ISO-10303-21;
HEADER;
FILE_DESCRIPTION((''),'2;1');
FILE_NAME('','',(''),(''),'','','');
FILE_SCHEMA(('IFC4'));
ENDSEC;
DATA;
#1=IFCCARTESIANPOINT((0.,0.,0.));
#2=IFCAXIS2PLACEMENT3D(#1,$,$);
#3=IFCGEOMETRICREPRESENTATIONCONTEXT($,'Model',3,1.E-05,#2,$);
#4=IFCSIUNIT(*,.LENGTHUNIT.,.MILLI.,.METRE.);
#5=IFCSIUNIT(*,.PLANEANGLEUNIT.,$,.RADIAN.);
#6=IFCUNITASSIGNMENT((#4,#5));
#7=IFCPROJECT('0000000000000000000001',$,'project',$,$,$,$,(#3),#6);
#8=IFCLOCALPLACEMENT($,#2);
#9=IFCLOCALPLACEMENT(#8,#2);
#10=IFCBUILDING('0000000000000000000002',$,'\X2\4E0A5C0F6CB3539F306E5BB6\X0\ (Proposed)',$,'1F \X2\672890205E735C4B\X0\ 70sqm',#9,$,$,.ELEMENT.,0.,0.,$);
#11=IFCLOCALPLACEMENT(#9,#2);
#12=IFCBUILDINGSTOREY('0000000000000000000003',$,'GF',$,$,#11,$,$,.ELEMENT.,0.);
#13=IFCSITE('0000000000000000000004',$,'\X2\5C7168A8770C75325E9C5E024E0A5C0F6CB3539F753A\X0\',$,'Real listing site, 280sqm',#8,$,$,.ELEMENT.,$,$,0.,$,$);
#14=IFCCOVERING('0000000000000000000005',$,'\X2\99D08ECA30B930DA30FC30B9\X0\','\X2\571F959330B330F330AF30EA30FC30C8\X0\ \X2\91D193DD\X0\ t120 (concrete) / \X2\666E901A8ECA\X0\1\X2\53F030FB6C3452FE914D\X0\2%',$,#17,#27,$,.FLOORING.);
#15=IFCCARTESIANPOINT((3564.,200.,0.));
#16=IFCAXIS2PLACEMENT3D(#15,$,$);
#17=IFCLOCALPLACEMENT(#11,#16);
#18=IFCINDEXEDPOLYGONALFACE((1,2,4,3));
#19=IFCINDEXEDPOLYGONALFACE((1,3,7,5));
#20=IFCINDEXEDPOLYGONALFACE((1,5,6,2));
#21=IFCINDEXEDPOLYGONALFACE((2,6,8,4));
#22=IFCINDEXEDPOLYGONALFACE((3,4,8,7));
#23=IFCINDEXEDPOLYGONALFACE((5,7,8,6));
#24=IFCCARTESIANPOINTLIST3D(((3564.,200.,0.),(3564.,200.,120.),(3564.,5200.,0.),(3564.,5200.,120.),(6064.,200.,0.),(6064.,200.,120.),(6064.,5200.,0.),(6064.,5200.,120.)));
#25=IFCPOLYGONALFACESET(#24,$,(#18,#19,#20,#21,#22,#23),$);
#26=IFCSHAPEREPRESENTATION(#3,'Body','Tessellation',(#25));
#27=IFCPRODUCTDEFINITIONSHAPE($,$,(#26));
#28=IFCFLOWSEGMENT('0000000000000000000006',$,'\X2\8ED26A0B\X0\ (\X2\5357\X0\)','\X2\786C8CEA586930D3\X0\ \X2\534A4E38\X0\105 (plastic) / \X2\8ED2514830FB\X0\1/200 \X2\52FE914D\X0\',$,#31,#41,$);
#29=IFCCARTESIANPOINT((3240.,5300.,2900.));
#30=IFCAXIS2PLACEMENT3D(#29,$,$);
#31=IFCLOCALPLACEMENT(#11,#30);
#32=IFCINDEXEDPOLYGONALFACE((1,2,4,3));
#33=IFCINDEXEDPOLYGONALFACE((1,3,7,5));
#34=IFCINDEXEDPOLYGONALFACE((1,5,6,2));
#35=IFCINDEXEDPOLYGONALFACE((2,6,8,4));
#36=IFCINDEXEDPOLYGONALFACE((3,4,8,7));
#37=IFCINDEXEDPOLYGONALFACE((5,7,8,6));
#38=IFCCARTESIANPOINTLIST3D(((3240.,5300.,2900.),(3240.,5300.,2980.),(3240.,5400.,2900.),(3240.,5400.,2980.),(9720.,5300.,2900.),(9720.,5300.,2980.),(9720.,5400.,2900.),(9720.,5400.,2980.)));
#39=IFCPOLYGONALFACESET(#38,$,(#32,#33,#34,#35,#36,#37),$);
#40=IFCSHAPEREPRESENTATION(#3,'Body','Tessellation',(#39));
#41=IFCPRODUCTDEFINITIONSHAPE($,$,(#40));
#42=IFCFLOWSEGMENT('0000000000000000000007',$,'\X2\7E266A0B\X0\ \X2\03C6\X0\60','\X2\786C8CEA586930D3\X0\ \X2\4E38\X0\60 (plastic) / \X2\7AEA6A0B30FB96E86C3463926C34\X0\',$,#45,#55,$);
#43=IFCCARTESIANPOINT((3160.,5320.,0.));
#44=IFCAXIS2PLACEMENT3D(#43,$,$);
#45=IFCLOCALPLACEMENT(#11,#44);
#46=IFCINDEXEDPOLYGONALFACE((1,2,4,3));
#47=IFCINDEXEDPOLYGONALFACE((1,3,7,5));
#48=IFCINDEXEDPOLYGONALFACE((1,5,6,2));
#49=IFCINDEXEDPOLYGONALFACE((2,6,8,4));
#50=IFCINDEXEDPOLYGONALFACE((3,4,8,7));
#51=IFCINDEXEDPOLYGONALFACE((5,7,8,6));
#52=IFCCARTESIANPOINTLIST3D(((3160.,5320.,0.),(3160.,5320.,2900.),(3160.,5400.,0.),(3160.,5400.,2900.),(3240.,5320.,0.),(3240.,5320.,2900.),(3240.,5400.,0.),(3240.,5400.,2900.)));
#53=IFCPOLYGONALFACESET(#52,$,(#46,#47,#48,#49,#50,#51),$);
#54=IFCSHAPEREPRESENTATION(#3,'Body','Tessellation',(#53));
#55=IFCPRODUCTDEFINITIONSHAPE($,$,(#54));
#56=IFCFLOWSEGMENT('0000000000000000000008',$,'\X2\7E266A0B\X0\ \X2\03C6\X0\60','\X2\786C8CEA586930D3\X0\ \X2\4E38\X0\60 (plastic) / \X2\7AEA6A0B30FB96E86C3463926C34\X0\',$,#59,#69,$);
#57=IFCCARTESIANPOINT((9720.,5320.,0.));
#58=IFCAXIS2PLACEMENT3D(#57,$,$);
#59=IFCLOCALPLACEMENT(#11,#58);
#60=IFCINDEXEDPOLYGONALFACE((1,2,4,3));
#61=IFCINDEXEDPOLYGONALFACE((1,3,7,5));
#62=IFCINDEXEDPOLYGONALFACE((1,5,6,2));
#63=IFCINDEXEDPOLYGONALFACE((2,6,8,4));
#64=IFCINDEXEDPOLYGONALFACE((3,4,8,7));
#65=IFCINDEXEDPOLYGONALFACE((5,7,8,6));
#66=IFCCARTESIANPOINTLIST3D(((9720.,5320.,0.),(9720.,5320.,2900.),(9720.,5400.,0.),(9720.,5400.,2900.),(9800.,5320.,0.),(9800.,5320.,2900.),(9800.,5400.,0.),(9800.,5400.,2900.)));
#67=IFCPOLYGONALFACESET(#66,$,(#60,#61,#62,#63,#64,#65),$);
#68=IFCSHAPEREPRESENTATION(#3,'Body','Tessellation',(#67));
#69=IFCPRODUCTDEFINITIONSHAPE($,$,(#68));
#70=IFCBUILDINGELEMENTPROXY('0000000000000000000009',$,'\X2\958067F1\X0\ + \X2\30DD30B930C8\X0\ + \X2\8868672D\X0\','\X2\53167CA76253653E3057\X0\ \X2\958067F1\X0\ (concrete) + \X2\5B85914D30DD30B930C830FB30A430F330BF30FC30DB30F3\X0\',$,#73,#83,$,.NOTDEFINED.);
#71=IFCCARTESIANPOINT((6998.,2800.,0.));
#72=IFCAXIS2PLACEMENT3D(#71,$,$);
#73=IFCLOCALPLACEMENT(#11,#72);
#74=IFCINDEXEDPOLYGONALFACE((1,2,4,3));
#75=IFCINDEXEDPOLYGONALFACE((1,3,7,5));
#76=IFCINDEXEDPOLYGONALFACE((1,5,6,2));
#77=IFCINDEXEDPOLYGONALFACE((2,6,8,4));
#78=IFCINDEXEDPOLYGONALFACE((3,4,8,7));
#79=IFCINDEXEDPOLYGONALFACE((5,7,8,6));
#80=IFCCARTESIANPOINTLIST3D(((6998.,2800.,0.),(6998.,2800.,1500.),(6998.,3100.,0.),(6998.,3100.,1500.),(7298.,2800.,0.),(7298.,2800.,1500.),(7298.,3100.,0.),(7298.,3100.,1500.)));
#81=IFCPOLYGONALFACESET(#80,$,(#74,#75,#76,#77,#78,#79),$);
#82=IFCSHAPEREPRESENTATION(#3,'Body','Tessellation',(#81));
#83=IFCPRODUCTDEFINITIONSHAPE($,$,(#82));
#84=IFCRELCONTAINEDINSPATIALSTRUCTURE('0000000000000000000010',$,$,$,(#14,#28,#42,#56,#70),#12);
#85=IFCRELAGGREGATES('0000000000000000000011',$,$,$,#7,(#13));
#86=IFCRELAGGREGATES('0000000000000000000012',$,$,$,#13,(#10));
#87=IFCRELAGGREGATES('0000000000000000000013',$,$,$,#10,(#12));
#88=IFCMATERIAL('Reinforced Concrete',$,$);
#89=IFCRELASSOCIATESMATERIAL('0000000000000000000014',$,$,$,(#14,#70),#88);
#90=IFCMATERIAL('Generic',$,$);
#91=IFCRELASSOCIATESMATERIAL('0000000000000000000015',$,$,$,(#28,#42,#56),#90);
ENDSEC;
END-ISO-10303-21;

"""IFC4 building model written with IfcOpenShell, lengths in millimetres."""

from ifc_helpers import new_model, si_unit, frame, frame_2d, origin, place, context, project, spatial, rectangle, extrude, material, element, save


model = new_model("IFC4")

# Units and contexts
model_context = context("Model", 3, precision=1e-05, world=origin())
ifc_project = project(units=[si_unit("LENGTHUNIT", "METRE", prefix="MILLI"), si_unit("PLANEANGLEUNIT", "RADIAN")], contexts=[model_context])

# Site, building, storey
site_placement = place(None, origin())
site = spatial("IfcSite", under=ifc_project, at=site_placement, Name="山梨県甲府市上小河原町", ObjectType="Real listing site, 280sqm", CompositionType="ELEMENT", RefElevation=0.0)
building_placement = place(site_placement, origin())
building = spatial("IfcBuilding", under=site, at=building_placement, Name="上小河原の家 (Proposed)", ObjectType="1F 木造平屋 70sqm", CompositionType="ELEMENT", ElevationOfRefHeight=0.0, ElevationOfTerrain=0.0)
storey_placement = place(building_placement, origin())
storey = spatial("IfcBuildingStorey", under=building, at=storey_placement, Name="GF", CompositionType="ELEMENT", Elevation=0.0)

# Shared definitions
ifc_material_1 = material(Name="Reinforced Concrete")

# Covering
covering_1_placement = place(storey_placement, frame((3564.0, 200.0, 0.0)))
element("IfcCovering", 1, at=covering_1_placement, inside=storey, material=ifc_material_1, Name="駐車スペース", Description="土間コンクリート 金鏝 t120 (concrete) / 普通車1台・水勾配2%", PredefinedType="FLOORING", context=model_context, shape_type="SweptSolid", body=[
    extrude(rectangle(XDim=2500.0, YDim=5000.0, at=frame_2d((1250.0, 2500.0))), frame((3564.0, 200.0, 0.0)), (0.0, 0.0, 1.0), 120.0),
])

# Flow segments
ifc_material_2 = material(Name="Generic")
flow_segment_1_placement = place(storey_placement, frame((3240.0, 5300.0, 2900.0)))
element("IfcFlowSegment", 2, at=flow_segment_1_placement, inside=storey, material=ifc_material_2, Name="軒樋 (南)", Description="硬質塩ビ 半丸105 (plastic) / 軒先・1/200 勾配", context=model_context, shape_type="SweptSolid", body=[
    extrude(rectangle(XDim=6480.0, YDim=100.0, at=frame_2d((3240.0, 50.0))), frame((3240.0, 5300.0, 2900.0)), (0.0, 0.0, 1.0), 80.0),
])
flow_segment_2_placement = place(storey_placement, frame((3160.0, 5320.0, 0.0)))
element("IfcFlowSegment", 3, at=flow_segment_2_placement, inside=storey, material=ifc_material_2, Name="縦樋 φ60", Description="硬質塩ビ 丸60 (plastic) / 竪樋・雨水排水", context=model_context, shape_type="SweptSolid", body=[
    extrude(rectangle(XDim=80.0, YDim=80.0, at=frame_2d((40.0, 40.0))), frame((3160.0, 5320.0, 0.0)), (0.0, 0.0, 1.0), 2900.0),
])
flow_segment_3_placement = place(storey_placement, frame((9720.0, 5320.0, 0.0)))
element("IfcFlowSegment", 4, at=flow_segment_3_placement, inside=storey, material=ifc_material_2, Name="縦樋 φ60", Description="硬質塩ビ 丸60 (plastic) / 竪樋・雨水排水", context=model_context, shape_type="SweptSolid", body=[
    extrude(rectangle(XDim=80.0, YDim=80.0, at=frame_2d((40.0, 40.0))), frame((9720.0, 5320.0, 0.0)), (0.0, 0.0, 1.0), 2900.0),
])

# Building element proxy
proxy_placement = place(storey_placement, frame((6998.0, 2800.0, 0.0)))
element("IfcBuildingElementProxy", 5, at=proxy_placement, inside=storey, material=ifc_material_1, Name="門柱 + ポスト + 表札", Description="化粧打放し 門柱 (concrete) + 宅配ポスト・インターホン", PredefinedType="NOTDEFINED", context=model_context, shape_type="SweptSolid", body=[
    extrude(rectangle(XDim=300.0, YDim=300.0, at=frame_2d((150.0, 150.0))), frame((6998.0, 2800.0, 0.0)), (0.0, 0.0, 1.0), 1500.0),
])

save(model, "model.ifc")
